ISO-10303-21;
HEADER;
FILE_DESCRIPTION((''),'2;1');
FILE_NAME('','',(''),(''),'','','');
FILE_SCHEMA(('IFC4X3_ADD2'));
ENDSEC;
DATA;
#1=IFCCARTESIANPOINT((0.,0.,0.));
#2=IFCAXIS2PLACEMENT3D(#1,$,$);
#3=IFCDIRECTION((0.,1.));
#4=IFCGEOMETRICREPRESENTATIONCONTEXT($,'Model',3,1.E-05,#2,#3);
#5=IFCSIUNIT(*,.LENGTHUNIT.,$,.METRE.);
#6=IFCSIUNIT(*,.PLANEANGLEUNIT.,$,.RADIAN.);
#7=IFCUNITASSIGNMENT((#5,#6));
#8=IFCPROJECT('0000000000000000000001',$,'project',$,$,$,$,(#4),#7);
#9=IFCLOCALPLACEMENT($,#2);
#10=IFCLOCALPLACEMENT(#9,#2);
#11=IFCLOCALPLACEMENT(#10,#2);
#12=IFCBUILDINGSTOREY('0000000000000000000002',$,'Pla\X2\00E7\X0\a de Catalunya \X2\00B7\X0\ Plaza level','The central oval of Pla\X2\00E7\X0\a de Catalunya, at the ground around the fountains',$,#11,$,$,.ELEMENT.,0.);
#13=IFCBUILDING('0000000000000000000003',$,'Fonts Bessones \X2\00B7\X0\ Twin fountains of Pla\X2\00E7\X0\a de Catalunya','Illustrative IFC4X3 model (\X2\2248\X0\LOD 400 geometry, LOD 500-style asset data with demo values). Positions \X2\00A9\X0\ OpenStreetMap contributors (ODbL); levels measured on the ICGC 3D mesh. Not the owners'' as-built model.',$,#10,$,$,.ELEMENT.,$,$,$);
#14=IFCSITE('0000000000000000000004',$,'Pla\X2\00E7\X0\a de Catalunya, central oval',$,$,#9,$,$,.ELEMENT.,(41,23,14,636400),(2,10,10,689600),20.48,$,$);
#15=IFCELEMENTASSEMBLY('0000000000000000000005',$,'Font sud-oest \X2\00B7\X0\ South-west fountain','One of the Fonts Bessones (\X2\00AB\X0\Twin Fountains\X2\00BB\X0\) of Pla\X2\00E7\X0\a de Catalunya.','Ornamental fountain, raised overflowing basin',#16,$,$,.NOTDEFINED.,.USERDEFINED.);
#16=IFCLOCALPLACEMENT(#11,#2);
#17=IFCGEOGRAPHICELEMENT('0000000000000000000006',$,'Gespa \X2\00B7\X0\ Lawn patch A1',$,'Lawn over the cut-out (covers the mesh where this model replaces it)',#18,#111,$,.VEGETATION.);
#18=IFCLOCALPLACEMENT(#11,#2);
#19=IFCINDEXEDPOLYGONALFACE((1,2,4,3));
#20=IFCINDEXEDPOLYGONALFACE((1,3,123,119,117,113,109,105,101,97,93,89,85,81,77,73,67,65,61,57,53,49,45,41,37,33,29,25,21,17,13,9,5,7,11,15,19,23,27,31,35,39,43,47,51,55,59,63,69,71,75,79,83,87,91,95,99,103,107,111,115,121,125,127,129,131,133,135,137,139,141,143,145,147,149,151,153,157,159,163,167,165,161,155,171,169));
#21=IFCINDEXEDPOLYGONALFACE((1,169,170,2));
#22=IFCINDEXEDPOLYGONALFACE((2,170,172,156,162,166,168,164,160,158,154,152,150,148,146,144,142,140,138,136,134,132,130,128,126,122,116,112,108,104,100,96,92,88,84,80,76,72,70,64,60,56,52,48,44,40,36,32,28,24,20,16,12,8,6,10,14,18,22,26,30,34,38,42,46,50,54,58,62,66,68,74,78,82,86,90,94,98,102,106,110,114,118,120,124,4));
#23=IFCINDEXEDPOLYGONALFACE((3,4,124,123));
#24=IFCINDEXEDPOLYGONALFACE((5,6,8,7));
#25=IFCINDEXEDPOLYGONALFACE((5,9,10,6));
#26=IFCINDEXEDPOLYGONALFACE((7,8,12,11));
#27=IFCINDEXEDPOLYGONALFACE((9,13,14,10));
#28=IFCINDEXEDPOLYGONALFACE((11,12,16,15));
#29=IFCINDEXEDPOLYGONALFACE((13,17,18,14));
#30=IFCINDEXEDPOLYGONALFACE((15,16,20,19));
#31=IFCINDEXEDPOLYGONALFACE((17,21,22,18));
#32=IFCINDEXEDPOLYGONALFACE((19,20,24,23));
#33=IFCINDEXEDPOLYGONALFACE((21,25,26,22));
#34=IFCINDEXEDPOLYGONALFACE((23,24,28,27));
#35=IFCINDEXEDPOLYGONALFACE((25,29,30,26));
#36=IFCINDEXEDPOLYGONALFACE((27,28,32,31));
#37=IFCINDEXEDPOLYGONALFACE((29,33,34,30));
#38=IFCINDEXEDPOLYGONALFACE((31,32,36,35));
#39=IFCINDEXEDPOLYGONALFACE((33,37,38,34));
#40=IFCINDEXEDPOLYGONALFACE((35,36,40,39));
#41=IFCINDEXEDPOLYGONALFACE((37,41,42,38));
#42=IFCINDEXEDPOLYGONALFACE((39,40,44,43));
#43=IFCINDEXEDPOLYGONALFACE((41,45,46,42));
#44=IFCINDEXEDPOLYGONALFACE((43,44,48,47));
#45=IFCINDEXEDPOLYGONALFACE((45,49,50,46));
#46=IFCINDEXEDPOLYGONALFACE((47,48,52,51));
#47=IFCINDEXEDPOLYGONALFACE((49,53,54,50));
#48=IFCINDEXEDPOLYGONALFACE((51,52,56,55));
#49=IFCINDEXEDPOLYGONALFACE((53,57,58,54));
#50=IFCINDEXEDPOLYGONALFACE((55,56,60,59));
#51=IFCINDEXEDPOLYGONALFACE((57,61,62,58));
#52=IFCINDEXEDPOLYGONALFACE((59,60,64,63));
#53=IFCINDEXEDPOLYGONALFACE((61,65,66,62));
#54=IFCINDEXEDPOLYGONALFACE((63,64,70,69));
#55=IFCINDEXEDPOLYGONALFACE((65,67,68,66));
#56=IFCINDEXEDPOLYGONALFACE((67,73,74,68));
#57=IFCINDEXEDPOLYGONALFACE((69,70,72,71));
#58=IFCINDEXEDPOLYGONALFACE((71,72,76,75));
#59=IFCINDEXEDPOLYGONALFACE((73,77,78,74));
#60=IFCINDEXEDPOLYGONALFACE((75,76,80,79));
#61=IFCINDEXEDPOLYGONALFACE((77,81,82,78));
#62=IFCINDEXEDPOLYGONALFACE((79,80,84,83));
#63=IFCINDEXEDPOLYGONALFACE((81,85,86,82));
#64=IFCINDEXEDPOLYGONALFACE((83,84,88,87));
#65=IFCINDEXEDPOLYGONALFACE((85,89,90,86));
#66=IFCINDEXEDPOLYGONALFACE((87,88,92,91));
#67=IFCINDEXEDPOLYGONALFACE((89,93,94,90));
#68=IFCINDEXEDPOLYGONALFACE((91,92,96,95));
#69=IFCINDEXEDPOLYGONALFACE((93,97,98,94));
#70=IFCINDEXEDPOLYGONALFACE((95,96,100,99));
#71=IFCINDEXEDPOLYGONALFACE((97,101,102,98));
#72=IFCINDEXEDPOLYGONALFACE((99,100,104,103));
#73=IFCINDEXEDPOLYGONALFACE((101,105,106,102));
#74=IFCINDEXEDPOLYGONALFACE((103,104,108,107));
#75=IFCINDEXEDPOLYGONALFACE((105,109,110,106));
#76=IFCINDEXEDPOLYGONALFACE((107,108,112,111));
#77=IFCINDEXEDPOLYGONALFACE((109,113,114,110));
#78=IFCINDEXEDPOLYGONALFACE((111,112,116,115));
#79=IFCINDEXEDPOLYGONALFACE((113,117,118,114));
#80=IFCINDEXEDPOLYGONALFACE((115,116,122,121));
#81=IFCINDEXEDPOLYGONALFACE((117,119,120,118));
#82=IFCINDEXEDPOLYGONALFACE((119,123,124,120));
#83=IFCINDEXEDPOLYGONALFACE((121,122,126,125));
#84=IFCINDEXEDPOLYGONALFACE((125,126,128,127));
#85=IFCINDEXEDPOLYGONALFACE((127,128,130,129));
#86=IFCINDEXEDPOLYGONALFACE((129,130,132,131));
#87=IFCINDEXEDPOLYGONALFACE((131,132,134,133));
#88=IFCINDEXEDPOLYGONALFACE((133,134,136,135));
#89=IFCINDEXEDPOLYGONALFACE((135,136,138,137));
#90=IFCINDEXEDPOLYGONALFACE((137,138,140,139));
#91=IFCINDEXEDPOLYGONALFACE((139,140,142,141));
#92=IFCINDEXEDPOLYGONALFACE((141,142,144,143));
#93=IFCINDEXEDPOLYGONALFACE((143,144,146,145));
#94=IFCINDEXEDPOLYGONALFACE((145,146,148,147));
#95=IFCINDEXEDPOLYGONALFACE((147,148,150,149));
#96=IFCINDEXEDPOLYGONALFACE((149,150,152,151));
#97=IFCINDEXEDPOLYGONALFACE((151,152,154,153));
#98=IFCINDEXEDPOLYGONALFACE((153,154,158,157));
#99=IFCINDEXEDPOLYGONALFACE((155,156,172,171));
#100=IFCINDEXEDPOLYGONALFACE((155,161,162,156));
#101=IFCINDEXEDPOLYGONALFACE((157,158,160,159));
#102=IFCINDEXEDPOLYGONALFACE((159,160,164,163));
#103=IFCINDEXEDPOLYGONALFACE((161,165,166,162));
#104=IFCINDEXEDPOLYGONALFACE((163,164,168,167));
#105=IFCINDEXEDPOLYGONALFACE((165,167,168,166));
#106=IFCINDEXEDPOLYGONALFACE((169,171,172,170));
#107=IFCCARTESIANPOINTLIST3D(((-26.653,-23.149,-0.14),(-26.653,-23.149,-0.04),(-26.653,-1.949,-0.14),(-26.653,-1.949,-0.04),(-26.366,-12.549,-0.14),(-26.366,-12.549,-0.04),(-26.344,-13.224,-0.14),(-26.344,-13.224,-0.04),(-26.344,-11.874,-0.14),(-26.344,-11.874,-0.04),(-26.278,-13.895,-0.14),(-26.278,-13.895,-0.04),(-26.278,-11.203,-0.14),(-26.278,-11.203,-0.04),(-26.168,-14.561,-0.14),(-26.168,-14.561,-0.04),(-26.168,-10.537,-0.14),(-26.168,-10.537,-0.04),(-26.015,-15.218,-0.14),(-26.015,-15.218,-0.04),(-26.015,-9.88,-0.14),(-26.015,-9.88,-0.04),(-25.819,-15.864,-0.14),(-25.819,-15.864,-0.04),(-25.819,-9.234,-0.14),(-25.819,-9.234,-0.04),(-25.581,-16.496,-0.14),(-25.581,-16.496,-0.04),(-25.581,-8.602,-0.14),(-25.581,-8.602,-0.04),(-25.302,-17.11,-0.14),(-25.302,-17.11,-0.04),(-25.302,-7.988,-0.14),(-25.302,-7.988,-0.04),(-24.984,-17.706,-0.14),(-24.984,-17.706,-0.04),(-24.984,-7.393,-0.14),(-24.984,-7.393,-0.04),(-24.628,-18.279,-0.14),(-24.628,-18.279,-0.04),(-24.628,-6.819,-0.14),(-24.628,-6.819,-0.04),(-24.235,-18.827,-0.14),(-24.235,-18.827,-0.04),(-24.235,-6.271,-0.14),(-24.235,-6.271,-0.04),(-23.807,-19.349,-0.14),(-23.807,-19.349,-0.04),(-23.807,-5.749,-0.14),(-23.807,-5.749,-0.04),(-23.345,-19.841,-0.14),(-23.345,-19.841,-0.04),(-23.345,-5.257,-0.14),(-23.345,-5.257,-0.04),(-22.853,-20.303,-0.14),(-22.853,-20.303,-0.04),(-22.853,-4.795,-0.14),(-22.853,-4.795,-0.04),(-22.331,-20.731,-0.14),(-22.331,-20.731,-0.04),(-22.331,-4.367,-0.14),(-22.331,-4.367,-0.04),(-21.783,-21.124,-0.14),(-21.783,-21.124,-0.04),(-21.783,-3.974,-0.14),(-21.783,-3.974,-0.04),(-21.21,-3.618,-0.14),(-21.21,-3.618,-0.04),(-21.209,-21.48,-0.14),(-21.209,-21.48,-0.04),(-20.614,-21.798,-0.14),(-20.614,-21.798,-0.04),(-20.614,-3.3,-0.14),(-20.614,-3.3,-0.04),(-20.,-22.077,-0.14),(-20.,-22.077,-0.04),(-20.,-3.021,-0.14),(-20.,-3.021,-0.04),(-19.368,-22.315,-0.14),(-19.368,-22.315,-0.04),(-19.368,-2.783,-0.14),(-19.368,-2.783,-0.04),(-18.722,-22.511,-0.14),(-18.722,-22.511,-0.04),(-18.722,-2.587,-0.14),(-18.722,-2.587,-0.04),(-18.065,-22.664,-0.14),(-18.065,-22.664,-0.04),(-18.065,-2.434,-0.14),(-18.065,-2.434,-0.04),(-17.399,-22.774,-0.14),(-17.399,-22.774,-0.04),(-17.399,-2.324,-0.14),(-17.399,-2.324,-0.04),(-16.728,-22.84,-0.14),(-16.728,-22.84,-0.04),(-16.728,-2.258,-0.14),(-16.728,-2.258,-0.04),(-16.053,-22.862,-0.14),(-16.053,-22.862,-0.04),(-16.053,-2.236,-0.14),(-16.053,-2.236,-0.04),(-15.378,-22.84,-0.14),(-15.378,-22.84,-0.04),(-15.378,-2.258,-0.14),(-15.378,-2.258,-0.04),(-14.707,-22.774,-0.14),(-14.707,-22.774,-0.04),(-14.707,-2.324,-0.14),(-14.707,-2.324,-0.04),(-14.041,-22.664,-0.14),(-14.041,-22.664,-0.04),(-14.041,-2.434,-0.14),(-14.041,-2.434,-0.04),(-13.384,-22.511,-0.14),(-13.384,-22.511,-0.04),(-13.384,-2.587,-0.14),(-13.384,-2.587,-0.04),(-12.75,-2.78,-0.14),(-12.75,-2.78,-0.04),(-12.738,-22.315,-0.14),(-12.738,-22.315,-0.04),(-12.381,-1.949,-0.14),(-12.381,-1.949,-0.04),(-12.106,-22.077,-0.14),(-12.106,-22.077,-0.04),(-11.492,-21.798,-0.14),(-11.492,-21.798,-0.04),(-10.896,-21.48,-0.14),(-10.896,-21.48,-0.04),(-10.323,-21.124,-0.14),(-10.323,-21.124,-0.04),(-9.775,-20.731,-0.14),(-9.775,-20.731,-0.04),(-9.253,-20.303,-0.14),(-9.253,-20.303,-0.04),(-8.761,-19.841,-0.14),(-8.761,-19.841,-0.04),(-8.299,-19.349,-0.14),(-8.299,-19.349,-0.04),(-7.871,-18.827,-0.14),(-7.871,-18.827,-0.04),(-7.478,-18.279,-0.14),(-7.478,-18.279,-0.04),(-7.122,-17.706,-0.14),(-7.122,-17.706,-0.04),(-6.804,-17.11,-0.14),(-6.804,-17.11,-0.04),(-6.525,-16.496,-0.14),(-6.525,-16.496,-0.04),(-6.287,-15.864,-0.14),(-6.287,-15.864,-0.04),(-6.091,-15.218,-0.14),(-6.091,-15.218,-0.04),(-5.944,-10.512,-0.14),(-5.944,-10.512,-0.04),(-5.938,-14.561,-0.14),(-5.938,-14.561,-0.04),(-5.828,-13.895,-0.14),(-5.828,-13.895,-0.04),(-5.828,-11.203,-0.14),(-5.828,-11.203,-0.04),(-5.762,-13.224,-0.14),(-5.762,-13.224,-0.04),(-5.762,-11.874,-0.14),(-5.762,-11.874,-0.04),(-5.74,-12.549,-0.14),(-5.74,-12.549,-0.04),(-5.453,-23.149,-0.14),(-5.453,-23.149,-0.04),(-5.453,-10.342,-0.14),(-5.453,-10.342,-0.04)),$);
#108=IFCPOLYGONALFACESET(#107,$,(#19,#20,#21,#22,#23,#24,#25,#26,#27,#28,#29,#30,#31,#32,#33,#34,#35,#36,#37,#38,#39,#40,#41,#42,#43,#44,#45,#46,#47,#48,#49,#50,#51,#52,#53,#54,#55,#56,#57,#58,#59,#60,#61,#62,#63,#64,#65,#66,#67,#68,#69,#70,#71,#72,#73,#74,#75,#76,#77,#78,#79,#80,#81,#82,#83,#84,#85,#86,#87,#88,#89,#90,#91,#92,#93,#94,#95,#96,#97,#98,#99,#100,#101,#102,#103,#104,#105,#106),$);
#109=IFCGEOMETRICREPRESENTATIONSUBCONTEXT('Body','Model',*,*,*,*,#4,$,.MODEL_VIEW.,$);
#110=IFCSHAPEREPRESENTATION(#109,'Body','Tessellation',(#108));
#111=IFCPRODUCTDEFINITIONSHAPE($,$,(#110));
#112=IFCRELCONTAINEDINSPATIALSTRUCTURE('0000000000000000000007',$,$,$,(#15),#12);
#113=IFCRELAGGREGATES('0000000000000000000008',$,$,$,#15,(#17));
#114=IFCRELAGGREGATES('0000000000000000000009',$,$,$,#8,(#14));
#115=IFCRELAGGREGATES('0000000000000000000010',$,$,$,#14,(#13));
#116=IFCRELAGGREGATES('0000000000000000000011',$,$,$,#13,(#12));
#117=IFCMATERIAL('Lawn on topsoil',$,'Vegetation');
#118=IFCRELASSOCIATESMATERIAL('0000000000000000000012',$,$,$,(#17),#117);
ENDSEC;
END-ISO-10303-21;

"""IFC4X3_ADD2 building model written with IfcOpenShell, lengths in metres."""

from ifc_helpers import new_model, si_unit, direction, frame, origin, place, context, subcontext, project, spatial, polyline, outline, extrude, material, element, aggregate, save


model = new_model("IFC4X3_ADD2")

# Units and contexts
model_context = context("Model", 3, precision=1e-05, world=origin(), true_north=direction((0.0, 1.0)))
body_context = subcontext(model_context, "Body", "Model", "MODEL_VIEW")
ifc_project = project(units=[si_unit("LENGTHUNIT", "METRE"), si_unit("PLANEANGLEUNIT", "RADIAN")], contexts=[model_context])

# Site, building, storey
site_placement = place(None, origin())
site = spatial("IfcSite", under=ifc_project, at=site_placement, Name="Plaça de Catalunya, central oval", CompositionType="ELEMENT", RefLatitude=(41, 23, 14, 636400), RefLongitude=(2, 10, 10, 689600), RefElevation=20.48)
building_placement = place(site_placement, origin())
building = spatial("IfcBuilding", under=site, at=building_placement, Name="Fonts Bessones · Twin fountains of Plaça de Catalunya", Description="Illustrative IFC4X3 model (≈LOD 400 geometry, LOD 500-style asset data with demo values). Positions © OpenStreetMap contributors (ODbL); levels measured on the ICGC 3D mesh. Not the owners' as-built model.", CompositionType="ELEMENT")
storey_placement = place(building_placement, origin())
storey = spatial("IfcBuildingStorey", under=building, at=storey_placement, Name="Plaça de Catalunya · Plaza level", Description="The central oval of Plaça de Catalunya, at the ground around the fountains", CompositionType="ELEMENT", Elevation=0.0)

# Element assembly
assembly_1_placement = place(building_placement, origin())
assembly_1 = element("IfcElementAssembly", 1, at=assembly_1_placement, inside=storey, Name="Font sud-oest · South-west fountain", Description="One of the Fonts Bessones («Twin Fountains») of Plaça de Catalunya.", ObjectType="Ornamental fountain, raised overflowing basin", AssemblyPlace="NOTDEFINED", PredefinedType="USERDEFINED")

# Geographic element
ifc_material_1 = material(Name="Lawn on topsoil", Category="Vegetation")
geographic_element_placement = place(building_placement, origin())
geographic_element = element("IfcGeographicElement", 2, at=geographic_element_placement, material=ifc_material_1, Name="Gespa · Lawn patch A1", ObjectType="Lawn over the cut-out (covers the mesh where this model replaces it)", PredefinedType="VEGETATION", context=body_context, shape_type="SweptSolid", body=[
    extrude(outline(polyline([(-26.653, -1.949), (-12.381, -1.949), (-12.75, -2.78), (-13.384, -2.587), (-14.041, -2.434), (-14.707, -2.324), (-15.378, -2.258), (-16.053, -2.236), (-16.728, -2.258), (-17.399, -2.324), (-18.065, -2.434), (-18.722, -2.587), (-19.368, -2.783), (-20.0, -3.021), (-20.614, -3.3), (-21.21, -3.618), (-21.783, -3.974), (-22.331, -4.367), (-22.853, -4.795), (-23.345, -5.257), (-23.807, -5.749), (-24.235, -6.271), (-24.628, -6.819), (-24.984, -7.393), (-25.302, -7.988), (-25.581, -8.602), (-25.819, -9.234), (-26.015, -9.88), (-26.168, -10.537), (-26.278, -11.203), (-26.344, -11.874), (-26.366, -12.549), (-26.344, -13.224), (-26.278, -13.895), (-26.168, -14.561), (-26.015, -15.218), (-25.819, -15.864), (-25.581, -16.496), (-25.302, -17.11), (-24.984, -17.706), (-24.628, -18.279), (-24.235, -18.827), (-23.807, -19.349), (-23.345, -19.841), (-22.853, -20.303), (-22.331, -20.731), (-21.783, -21.124), (-21.209, -21.48), (-20.614, -21.798), (-20.0, -22.077), (-19.368, -22.315), (-18.722, -22.511), (-18.065, -22.664), (-17.399, -22.774), (-16.728, -22.84), (-16.053, -22.862), (-15.378, -22.84), (-14.707, -22.774), (-14.041, -22.664), (-13.384, -22.511), (-12.738, -22.315), (-12.106, -22.077), (-11.492, -21.798), (-10.896, -21.48), (-10.323, -21.124), (-9.775, -20.731), (-9.253, -20.303), (-8.761, -19.841), (-8.299, -19.349), (-7.871, -18.827), (-7.478, -18.279), (-7.122, -17.706), (-6.804, -17.11), (-6.525, -16.496), (-6.287, -15.864), (-6.091, -15.218), (-5.938, -14.561), (-5.828, -13.895), (-5.762, -13.224), (-5.74, -12.549), (-5.762, -11.874), (-5.828, -11.203), (-5.944, -10.512), (-5.453, -10.342), (-5.453, -23.149), (-26.653, -23.149), (-26.653, -1.949)]), holes=[]), frame((0.0, 0.0, -0.14)), (0.0, 0.0, 1.0), 0.1),
])
aggregate(assembly_1, [geographic_element])

save(model, "model.ifc")
